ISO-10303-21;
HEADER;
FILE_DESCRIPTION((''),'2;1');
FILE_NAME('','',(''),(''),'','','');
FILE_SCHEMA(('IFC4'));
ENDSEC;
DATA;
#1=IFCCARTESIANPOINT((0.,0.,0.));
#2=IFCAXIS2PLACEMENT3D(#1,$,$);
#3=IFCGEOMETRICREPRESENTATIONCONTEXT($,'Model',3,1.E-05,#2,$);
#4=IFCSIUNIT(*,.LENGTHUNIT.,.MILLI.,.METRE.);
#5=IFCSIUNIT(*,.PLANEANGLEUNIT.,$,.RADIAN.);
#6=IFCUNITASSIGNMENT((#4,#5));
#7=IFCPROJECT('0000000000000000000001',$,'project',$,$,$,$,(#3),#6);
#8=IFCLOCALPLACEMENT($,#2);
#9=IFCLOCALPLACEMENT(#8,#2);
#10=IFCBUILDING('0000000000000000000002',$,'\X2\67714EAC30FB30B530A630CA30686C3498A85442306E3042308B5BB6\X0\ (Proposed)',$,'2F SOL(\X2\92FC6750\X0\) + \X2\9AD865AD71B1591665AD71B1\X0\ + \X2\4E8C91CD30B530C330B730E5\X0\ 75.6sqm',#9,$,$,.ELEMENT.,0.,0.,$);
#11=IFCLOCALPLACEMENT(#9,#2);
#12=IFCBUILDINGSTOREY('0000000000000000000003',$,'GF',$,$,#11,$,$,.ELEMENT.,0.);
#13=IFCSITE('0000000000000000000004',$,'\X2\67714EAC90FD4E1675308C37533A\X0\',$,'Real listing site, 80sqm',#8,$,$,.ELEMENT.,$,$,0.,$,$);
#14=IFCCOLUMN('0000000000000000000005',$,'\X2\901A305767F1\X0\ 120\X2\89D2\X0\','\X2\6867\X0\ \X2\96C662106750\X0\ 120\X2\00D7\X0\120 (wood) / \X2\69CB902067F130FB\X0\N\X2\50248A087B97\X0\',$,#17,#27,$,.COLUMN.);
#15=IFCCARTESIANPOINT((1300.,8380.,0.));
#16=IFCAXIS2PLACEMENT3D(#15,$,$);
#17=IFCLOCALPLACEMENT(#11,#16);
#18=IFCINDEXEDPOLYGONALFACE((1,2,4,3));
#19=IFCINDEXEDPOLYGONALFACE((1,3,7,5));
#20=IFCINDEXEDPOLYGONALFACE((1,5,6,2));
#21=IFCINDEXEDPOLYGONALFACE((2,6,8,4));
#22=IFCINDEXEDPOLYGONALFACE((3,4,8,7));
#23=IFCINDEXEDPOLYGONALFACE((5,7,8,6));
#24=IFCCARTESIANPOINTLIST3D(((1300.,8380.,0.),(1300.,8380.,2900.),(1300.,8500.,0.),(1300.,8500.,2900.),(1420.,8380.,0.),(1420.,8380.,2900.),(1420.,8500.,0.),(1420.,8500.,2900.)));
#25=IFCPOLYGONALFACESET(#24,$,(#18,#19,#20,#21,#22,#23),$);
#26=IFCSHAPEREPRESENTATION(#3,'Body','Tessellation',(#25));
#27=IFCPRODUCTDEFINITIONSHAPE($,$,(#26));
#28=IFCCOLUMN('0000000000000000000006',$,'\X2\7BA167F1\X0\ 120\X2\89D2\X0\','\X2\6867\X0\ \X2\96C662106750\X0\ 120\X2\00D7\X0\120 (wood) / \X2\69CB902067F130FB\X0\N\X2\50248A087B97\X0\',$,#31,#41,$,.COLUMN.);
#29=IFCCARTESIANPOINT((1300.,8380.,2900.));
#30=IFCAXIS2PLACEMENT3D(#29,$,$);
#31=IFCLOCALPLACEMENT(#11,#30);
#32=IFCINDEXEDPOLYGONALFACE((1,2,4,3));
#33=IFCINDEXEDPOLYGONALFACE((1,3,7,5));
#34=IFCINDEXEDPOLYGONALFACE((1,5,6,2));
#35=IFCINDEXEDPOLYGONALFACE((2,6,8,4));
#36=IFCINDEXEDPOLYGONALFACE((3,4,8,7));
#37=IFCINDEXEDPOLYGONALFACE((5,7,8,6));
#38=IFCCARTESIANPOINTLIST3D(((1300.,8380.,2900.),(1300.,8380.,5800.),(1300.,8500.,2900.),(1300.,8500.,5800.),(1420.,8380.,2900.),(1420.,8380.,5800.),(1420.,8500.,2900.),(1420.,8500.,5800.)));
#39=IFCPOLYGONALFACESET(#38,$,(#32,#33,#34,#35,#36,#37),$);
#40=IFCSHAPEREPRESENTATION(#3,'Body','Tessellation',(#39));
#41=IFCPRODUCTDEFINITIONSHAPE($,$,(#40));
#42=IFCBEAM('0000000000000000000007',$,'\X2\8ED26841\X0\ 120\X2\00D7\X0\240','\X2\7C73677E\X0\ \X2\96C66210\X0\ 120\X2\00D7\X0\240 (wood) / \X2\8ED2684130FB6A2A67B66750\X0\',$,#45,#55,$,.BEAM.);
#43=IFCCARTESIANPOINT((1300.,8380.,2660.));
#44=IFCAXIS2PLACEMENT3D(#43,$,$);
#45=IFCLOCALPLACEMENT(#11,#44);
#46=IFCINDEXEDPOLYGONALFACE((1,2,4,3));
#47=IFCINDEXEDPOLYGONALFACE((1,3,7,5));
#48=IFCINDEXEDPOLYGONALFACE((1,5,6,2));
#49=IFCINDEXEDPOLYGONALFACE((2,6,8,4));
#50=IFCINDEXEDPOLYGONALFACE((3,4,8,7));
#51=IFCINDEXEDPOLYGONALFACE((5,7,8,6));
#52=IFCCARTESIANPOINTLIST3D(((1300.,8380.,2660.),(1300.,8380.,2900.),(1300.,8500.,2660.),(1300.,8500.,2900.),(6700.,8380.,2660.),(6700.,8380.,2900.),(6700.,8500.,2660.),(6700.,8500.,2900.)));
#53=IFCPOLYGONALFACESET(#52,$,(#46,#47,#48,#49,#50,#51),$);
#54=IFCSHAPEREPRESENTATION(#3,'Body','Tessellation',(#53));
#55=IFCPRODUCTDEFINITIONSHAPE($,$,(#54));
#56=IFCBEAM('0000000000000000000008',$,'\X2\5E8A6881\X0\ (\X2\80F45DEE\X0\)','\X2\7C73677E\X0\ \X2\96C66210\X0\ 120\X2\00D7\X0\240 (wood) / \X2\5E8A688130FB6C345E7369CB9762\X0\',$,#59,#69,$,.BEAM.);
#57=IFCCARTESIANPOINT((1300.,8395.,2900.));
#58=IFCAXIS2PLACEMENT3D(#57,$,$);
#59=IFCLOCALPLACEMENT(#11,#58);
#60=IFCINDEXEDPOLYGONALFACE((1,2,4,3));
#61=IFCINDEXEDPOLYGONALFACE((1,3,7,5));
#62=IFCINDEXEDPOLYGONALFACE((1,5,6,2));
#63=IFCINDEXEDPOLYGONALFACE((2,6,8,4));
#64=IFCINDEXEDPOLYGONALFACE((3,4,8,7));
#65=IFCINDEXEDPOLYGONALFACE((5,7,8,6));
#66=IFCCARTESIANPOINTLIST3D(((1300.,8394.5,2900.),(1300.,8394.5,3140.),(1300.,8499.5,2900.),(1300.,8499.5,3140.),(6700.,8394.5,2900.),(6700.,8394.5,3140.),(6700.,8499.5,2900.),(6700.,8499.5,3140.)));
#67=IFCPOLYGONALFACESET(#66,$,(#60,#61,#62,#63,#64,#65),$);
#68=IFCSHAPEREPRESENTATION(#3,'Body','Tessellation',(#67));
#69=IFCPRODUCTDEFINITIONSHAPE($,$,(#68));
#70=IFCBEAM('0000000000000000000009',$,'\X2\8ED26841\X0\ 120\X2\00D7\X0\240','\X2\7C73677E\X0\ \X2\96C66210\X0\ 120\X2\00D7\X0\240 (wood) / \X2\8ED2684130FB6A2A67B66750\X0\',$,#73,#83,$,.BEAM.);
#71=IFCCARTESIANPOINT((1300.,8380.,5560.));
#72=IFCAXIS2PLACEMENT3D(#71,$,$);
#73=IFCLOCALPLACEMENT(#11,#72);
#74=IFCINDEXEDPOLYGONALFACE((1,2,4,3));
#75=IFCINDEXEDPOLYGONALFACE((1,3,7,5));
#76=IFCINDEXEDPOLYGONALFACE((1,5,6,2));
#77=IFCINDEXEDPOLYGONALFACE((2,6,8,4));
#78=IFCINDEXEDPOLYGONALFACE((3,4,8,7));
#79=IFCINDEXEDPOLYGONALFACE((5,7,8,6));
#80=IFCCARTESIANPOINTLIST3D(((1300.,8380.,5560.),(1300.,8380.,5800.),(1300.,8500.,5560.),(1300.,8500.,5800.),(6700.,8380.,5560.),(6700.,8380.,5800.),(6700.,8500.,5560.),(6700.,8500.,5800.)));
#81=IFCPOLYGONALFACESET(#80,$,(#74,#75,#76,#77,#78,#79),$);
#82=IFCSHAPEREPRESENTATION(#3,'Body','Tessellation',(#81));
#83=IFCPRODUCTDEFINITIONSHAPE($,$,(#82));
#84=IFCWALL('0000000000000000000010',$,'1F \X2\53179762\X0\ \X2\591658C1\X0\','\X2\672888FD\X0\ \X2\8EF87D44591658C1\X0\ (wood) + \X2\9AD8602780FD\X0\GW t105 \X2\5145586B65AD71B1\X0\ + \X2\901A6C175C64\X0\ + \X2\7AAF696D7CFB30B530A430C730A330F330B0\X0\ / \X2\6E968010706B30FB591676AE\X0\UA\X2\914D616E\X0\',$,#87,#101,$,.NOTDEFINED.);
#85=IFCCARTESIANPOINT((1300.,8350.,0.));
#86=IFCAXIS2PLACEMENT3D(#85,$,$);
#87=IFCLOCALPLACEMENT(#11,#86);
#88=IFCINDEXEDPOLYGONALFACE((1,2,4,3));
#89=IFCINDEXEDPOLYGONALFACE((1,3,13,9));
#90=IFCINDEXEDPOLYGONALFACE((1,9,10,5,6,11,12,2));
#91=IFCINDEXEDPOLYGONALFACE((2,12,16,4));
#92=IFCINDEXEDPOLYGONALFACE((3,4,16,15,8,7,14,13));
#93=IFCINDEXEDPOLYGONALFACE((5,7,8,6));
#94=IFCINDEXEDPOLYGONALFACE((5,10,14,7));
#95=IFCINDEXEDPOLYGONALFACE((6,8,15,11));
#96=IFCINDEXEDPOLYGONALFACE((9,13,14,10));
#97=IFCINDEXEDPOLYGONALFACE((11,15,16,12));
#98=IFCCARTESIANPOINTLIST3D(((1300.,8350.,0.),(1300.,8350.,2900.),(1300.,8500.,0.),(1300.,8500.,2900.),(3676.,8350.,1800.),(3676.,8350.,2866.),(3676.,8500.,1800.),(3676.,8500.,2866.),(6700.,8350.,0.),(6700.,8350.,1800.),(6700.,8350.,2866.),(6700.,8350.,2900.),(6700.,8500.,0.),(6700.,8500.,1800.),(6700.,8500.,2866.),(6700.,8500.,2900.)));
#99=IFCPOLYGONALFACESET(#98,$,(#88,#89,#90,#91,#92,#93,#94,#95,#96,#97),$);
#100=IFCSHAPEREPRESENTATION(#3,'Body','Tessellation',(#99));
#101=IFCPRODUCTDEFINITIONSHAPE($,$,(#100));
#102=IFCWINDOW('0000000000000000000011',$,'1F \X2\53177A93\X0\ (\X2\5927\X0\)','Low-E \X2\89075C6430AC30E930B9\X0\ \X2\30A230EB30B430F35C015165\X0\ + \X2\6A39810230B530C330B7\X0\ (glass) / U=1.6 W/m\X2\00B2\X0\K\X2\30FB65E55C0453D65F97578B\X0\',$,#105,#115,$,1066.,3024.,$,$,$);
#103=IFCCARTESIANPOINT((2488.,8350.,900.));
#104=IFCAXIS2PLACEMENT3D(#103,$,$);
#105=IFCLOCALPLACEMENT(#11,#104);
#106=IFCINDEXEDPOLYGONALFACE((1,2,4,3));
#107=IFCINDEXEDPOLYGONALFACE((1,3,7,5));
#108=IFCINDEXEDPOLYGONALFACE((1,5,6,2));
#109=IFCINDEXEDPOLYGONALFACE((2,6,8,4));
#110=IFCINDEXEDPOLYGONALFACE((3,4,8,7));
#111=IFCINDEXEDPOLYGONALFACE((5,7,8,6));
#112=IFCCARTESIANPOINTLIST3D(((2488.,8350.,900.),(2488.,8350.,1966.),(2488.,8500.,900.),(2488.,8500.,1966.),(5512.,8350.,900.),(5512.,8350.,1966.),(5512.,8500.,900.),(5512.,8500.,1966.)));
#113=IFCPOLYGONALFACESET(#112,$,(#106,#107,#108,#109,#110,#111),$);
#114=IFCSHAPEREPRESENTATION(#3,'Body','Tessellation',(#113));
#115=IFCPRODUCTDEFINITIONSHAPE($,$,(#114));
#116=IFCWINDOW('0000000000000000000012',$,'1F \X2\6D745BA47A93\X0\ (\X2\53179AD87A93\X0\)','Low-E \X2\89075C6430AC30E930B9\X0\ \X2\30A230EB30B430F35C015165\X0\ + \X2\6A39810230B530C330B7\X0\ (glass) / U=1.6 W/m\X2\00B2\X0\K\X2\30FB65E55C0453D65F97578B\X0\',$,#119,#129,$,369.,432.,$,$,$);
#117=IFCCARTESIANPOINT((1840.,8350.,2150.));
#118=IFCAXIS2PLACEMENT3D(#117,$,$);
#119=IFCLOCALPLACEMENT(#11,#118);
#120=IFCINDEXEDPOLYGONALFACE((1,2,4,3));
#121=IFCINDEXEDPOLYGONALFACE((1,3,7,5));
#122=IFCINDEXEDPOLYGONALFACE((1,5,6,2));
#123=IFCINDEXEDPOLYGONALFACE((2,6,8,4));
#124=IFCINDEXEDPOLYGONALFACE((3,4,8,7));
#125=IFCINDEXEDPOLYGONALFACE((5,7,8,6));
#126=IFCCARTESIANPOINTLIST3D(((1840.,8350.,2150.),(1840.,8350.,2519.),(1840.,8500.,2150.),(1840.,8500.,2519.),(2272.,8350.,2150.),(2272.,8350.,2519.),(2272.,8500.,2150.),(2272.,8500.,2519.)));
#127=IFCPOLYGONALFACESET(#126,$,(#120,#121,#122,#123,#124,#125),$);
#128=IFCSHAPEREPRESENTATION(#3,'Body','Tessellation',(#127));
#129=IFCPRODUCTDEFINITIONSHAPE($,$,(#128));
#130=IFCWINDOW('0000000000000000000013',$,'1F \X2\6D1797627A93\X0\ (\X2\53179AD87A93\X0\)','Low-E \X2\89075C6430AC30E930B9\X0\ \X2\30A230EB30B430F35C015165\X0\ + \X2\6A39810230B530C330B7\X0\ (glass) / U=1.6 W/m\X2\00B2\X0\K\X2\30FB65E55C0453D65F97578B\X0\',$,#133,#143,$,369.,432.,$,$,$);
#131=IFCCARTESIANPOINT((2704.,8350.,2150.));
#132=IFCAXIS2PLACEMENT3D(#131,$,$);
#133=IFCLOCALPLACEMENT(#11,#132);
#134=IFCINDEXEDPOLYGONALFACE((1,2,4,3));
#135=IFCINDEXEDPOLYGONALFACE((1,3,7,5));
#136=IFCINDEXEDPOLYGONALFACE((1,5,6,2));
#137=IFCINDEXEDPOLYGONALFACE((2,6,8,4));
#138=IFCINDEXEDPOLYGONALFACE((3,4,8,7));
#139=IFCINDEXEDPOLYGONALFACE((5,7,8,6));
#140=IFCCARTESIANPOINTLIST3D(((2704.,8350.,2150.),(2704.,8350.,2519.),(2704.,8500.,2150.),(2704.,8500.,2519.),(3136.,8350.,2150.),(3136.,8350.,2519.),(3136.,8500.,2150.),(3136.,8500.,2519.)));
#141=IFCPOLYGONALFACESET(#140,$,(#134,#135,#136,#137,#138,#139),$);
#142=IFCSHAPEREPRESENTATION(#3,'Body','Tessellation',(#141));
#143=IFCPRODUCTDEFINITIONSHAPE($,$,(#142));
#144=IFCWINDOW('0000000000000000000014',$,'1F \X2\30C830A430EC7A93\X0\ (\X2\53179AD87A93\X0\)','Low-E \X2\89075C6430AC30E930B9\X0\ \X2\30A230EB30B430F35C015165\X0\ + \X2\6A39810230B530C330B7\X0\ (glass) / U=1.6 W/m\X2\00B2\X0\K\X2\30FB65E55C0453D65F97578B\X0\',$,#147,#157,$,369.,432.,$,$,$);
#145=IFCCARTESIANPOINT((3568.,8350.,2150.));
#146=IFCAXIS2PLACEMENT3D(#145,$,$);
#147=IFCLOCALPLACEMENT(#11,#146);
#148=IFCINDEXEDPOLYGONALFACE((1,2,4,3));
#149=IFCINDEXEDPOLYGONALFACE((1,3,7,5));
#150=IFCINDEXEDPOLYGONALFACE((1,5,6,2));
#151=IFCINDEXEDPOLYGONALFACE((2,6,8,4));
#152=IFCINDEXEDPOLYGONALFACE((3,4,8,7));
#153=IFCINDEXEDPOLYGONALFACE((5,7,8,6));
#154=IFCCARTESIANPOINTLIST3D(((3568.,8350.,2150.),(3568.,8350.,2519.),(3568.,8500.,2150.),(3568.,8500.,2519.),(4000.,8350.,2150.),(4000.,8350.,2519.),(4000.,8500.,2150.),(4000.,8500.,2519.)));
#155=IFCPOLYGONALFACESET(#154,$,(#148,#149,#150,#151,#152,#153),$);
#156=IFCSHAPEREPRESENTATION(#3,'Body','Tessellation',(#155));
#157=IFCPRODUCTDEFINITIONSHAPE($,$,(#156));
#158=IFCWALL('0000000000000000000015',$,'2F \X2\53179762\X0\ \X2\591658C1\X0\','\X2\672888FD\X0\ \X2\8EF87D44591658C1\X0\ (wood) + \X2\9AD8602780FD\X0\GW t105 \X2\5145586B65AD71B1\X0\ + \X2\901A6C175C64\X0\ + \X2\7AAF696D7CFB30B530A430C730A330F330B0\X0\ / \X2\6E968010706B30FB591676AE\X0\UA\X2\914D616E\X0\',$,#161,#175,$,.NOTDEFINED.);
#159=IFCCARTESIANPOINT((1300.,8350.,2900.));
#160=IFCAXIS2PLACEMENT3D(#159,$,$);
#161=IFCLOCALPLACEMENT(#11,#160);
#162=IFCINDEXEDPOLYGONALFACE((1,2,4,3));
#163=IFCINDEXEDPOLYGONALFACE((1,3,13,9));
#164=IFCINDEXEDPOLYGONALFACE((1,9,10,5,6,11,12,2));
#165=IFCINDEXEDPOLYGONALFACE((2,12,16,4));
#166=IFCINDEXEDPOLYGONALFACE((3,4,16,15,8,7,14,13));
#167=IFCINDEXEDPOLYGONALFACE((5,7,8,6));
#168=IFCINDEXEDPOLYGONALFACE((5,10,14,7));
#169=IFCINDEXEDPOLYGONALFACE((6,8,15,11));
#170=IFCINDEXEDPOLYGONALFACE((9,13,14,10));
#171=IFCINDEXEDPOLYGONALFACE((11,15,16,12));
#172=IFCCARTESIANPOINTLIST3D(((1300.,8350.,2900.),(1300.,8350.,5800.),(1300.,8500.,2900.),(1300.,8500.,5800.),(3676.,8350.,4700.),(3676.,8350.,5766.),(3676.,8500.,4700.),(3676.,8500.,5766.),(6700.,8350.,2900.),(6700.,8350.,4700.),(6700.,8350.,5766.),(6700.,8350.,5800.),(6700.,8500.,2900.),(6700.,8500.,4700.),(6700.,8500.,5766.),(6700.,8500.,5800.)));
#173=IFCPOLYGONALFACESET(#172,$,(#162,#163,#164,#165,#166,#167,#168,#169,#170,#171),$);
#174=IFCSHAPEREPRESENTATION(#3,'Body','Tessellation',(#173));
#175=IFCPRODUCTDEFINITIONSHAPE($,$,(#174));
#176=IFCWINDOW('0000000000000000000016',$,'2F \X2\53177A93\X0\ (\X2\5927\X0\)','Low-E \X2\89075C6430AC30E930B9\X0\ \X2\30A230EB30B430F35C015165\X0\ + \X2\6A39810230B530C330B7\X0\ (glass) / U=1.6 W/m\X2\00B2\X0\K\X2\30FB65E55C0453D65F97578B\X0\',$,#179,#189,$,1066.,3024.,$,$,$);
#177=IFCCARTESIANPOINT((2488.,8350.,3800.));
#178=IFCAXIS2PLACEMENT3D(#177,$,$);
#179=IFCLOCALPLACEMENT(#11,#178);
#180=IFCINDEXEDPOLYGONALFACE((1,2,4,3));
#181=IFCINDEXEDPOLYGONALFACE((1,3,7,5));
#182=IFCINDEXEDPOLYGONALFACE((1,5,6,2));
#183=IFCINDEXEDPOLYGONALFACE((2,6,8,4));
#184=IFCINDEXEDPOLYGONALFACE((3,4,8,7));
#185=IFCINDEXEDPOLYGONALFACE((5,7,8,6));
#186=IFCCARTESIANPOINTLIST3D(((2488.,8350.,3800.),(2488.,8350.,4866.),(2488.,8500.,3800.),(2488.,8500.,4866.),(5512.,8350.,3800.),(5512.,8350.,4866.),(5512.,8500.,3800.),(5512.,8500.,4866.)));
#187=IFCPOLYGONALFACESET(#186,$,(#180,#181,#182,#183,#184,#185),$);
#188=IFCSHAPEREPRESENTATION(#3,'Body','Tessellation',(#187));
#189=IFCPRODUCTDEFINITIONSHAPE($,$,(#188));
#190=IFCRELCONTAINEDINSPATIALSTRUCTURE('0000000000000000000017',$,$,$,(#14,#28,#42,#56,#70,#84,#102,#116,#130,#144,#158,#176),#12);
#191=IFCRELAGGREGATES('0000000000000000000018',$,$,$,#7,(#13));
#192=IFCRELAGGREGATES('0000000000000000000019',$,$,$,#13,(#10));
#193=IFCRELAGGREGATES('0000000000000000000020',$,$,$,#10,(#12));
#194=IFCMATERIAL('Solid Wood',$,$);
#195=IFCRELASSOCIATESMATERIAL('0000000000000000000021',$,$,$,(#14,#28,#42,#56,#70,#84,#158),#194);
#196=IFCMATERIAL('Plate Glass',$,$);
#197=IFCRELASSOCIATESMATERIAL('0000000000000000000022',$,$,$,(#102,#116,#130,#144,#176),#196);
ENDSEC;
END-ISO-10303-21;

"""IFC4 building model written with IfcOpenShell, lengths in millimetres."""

from ifc_helpers import new_model, si_unit, frame, frame_2d, origin, place, context, project, spatial, rectangle, extrude, material, element, fill, save


model = new_model("IFC4")

# Units and contexts
model_context = context("Model", 3, precision=1e-05, world=origin())
ifc_project = project(units=[si_unit("LENGTHUNIT", "METRE", prefix="MILLI"), si_unit("PLANEANGLEUNIT", "RADIAN")], contexts=[model_context])

# Site, building, storey
site_placement = place(None, origin())
site = spatial("IfcSite", under=ifc_project, at=site_placement, Name="東京都世田谷区", ObjectType="Real listing site, 80sqm", CompositionType="ELEMENT", RefElevation=0.0)
building_placement = place(site_placement, origin())
building = spatial("IfcBuilding", under=site, at=building_placement, Name="東京・サウナと水風呂のある家 (Proposed)", ObjectType="2F SOL(鋼材) + 高断熱外断熱 + 二重サッシュ 75.6sqm", CompositionType="ELEMENT", ElevationOfRefHeight=0.0, ElevationOfTerrain=0.0)
storey_placement = place(building_placement, origin())
storey = spatial("IfcBuildingStorey", under=building, at=storey_placement, Name="GF", CompositionType="ELEMENT", Elevation=0.0)

# Columns
ifc_material_1 = material(Name="Solid Wood")
column_1_placement = place(storey_placement, frame((1300.0, 8380.0, 0.0)))
element("IfcColumn", 1, at=column_1_placement, inside=storey, material=ifc_material_1, Name="通し柱 120角", Description="桧 集成材 120×120 (wood) / 構造柱・N値計算", PredefinedType="COLUMN", context=model_context, shape_type="SweptSolid", body=[
    extrude(rectangle(XDim=120.0, YDim=120.0, at=frame_2d((60.0, 60.0))), frame((1300.0, 8380.0, 0.0)), (0.0, 0.0, 1.0), 2900.0),
])
column_2_placement = place(storey_placement, frame((1300.0, 8380.0, 2900.0)))
element("IfcColumn", 2, at=column_2_placement, inside=storey, material=ifc_material_1, Name="管柱 120角", Description="桧 集成材 120×120 (wood) / 構造柱・N値計算", PredefinedType="COLUMN", context=model_context, shape_type="SweptSolid", body=[
    extrude(rectangle(XDim=120.0, YDim=120.0, at=frame_2d((60.0, 60.0))), frame((1300.0, 8380.0, 2900.0)), (0.0, 0.0, 1.0), 2900.0),
])

# Beams
beam_1_placement = place(storey_placement, frame((1300.0, 8380.0, 2660.0)))
element("IfcBeam", 3, at=beam_1_placement, inside=storey, material=ifc_material_1, Name="軒桁 120×240", Description="米松 集成 120×240 (wood) / 軒桁・横架材", PredefinedType="BEAM", context=model_context, shape_type="SweptSolid", body=[
    extrude(rectangle(XDim=5400.0, YDim=120.0, at=frame_2d((2700.0, 60.0))), frame((1300.0, 8380.0, 2660.0)), (0.0, 0.0, 1.0), 240.0),
])
beam_2_placement = place(storey_placement, frame((1300.0, 8395.0, 2900.0)))
element("IfcBeam", 4, at=beam_2_placement, inside=storey, material=ifc_material_1, Name="床梁 (胴差)", Description="米松 集成 120×240 (wood) / 床梁・水平構面", PredefinedType="BEAM", context=model_context, shape_type="SweptSolid", body=[
    extrude(rectangle(XDim=5400.0, YDim=105.0, at=frame_2d((2700.0, 52.0))), frame((1300.0, 8395.0, 2900.0)), (0.0, 0.0, 1.0), 240.0),
])
beam_3_placement = place(storey_placement, frame((1300.0, 8380.0, 5560.0)))
element("IfcBeam", 5, at=beam_3_placement, inside=storey, material=ifc_material_1, Name="軒桁 120×240", Description="米松 集成 120×240 (wood) / 軒桁・横架材", PredefinedType="BEAM", context=model_context, shape_type="SweptSolid", body=[
    extrude(rectangle(XDim=5400.0, YDim=120.0, at=frame_2d((2700.0, 60.0))), frame((1300.0, 8380.0, 5560.0)), (0.0, 0.0, 1.0), 240.0),
])

# Wall, openings, windows
wall_1_placement = place(storey_placement, frame((1300.0, 8350.0, 0.0)))
wall_1 = element("IfcWall", 6, at=wall_1_placement, inside=storey, material=ifc_material_1, Name="1F 北面 外壁", Description="木製 軸組外壁 (wood) + 高性能GW t105 充填断熱 + 通気層 + 窯業系サイディング / 準耐火・外皮UA配慮", PredefinedType="NOTDEFINED", context=model_context, shape_type="SweptSolid", body=[
    extrude(rectangle(XDim=5400.0, YDim=150.0, at=frame_2d((2700.0, 75.0))), frame((1300.0, 8350.0, 0.0)), (0.0, 0.0, 1.0), 2900.0),
])
opening_1_placement = place(storey_placement, frame((2488.0, 8350.0, 900.0)))
opening_1 = element("IfcOpeningElement", 7, at=opening_1_placement, cuts=wall_1, PredefinedType="NOTDEFINED", context=model_context, shape_type="SweptSolid", body=[
    extrude(rectangle(XDim=3024.0, YDim=150.0, at=frame_2d((1512.0, 75.0))), frame((2488.0, 8350.0, 900.0)), (0.0, 0.0, 1.0), 1066.0),
])
opening_2_placement = place(storey_placement, frame((1840.0, 8350.0, 2150.0)))
opening_2 = element("IfcOpeningElement", 8, at=opening_2_placement, cuts=wall_1, PredefinedType="NOTDEFINED", context=model_context, shape_type="SweptSolid", body=[
    extrude(rectangle(XDim=432.0, YDim=150.0, at=frame_2d((216.0, 75.0))), frame((1840.0, 8350.0, 2150.0)), (0.0, 0.0, 1.0), 369.0),
])
opening_3_placement = place(storey_placement, frame((2704.0, 8350.0, 2150.0)))
opening_3 = element("IfcOpeningElement", 9, at=opening_3_placement, cuts=wall_1, PredefinedType="NOTDEFINED", context=model_context, shape_type="SweptSolid", body=[
    extrude(rectangle(XDim=432.0, YDim=150.0, at=frame_2d((216.0, 75.0))), frame((2704.0, 8350.0, 2150.0)), (0.0, 0.0, 1.0), 369.0),
])
opening_4_placement = place(storey_placement, frame((3568.0, 8350.0, 2150.0)))
opening_4 = element("IfcOpeningElement", 10, at=opening_4_placement, cuts=wall_1, PredefinedType="NOTDEFINED", context=model_context, shape_type="SweptSolid", body=[
    extrude(rectangle(XDim=432.0, YDim=150.0, at=frame_2d((216.0, 75.0))), frame((3568.0, 8350.0, 2150.0)), (0.0, 0.0, 1.0), 369.0),
])
ifc_material_2 = material(Name="Plate Glass")
window_1_placement = place(storey_placement, frame((2488.0, 8350.0, 900.0)))
window_1 = element("IfcWindow", 11, at=window_1_placement, inside=storey, material=ifc_material_2, Name="1F 北窓 (大)", Description="Low-E 複層ガラス アルゴン封入 + 樹脂サッシ (glass) / U=1.6 W/m²K・日射取得型", OverallHeight=1066.0, OverallWidth=3024.0, context=model_context, shape_type="SweptSolid", body=[
    extrude(rectangle(XDim=3024.0, YDim=150.0, at=frame_2d((1512.0, 75.0))), frame((2488.0, 8350.0, 900.0)), (0.0, 0.0, 1.0), 1066.0),
])
fill(opening_1, window_1)
window_2_placement = place(storey_placement, frame((1840.0, 8350.0, 2150.0)))
window_2 = element("IfcWindow", 12, at=window_2_placement, inside=storey, material=ifc_material_2, Name="1F 浴室窓 (北高窓)", Description="Low-E 複層ガラス アルゴン封入 + 樹脂サッシ (glass) / U=1.6 W/m²K・日射取得型", OverallHeight=369.0, OverallWidth=432.0, context=model_context, shape_type="SweptSolid", body=[
    extrude(rectangle(XDim=432.0, YDim=150.0, at=frame_2d((216.0, 75.0))), frame((1840.0, 8350.0, 2150.0)), (0.0, 0.0, 1.0), 369.0),
])
fill(opening_2, window_2)
window_3_placement = place(storey_placement, frame((2704.0, 8350.0, 2150.0)))
window_3 = element("IfcWindow", 13, at=window_3_placement, inside=storey, material=ifc_material_2, Name="1F 洗面窓 (北高窓)", Description="Low-E 複層ガラス アルゴン封入 + 樹脂サッシ (glass) / U=1.6 W/m²K・日射取得型", OverallHeight=369.0, OverallWidth=432.0, context=model_context, shape_type="SweptSolid", body=[
    extrude(rectangle(XDim=432.0, YDim=150.0, at=frame_2d((216.0, 75.0))), frame((2704.0, 8350.0, 2150.0)), (0.0, 0.0, 1.0), 369.0),
])
fill(opening_3, window_3)
window_4_placement = place(storey_placement, frame((3568.0, 8350.0, 2150.0)))
window_4 = element("IfcWindow", 14, at=window_4_placement, inside=storey, material=ifc_material_2, Name="1F トイレ窓 (北高窓)", Description="Low-E 複層ガラス アルゴン封入 + 樹脂サッシ (glass) / U=1.6 W/m²K・日射取得型", OverallHeight=369.0, OverallWidth=432.0, context=model_context, shape_type="SweptSolid", body=[
    extrude(rectangle(XDim=432.0, YDim=150.0, at=frame_2d((216.0, 75.0))), frame((3568.0, 8350.0, 2150.0)), (0.0, 0.0, 1.0), 369.0),
])
fill(opening_4, window_4)

# Wall, opening, window
wall_2_placement = place(storey_placement, frame((1300.0, 8350.0, 2900.0)))
wall_2 = element("IfcWall", 15, at=wall_2_placement, inside=storey, material=ifc_material_1, Name="2F 北面 外壁", Description="木製 軸組外壁 (wood) + 高性能GW t105 充填断熱 + 通気層 + 窯業系サイディング / 準耐火・外皮UA配慮", PredefinedType="NOTDEFINED", context=model_context, shape_type="SweptSolid", body=[
    extrude(rectangle(XDim=5400.0, YDim=150.0, at=frame_2d((2700.0, 75.0))), frame((1300.0, 8350.0, 2900.0)), (0.0, 0.0, 1.0), 2900.0),
])
opening_5_placement = place(storey_placement, frame((2488.0, 8350.0, 3800.0)))
opening_5 = element("IfcOpeningElement", 16, at=opening_5_placement, cuts=wall_2, PredefinedType="NOTDEFINED", context=model_context, shape_type="SweptSolid", body=[
    extrude(rectangle(XDim=3024.0, YDim=150.0, at=frame_2d((1512.0, 75.0))), frame((2488.0, 8350.0, 3800.0)), (0.0, 0.0, 1.0), 1066.0),
])
window_5_placement = place(storey_placement, frame((2488.0, 8350.0, 3800.0)))
window_5 = element("IfcWindow", 17, at=window_5_placement, inside=storey, material=ifc_material_2, Name="2F 北窓 (大)", Description="Low-E 複層ガラス アルゴン封入 + 樹脂サッシ (glass) / U=1.6 W/m²K・日射取得型", OverallHeight=1066.0, OverallWidth=3024.0, context=model_context, shape_type="SweptSolid", body=[
    extrude(rectangle(XDim=3024.0, YDim=150.0, at=frame_2d((1512.0, 75.0))), frame((2488.0, 8350.0, 3800.0)), (0.0, 0.0, 1.0), 1066.0),
])
fill(opening_5, window_5)

save(model, "model.ifc")
